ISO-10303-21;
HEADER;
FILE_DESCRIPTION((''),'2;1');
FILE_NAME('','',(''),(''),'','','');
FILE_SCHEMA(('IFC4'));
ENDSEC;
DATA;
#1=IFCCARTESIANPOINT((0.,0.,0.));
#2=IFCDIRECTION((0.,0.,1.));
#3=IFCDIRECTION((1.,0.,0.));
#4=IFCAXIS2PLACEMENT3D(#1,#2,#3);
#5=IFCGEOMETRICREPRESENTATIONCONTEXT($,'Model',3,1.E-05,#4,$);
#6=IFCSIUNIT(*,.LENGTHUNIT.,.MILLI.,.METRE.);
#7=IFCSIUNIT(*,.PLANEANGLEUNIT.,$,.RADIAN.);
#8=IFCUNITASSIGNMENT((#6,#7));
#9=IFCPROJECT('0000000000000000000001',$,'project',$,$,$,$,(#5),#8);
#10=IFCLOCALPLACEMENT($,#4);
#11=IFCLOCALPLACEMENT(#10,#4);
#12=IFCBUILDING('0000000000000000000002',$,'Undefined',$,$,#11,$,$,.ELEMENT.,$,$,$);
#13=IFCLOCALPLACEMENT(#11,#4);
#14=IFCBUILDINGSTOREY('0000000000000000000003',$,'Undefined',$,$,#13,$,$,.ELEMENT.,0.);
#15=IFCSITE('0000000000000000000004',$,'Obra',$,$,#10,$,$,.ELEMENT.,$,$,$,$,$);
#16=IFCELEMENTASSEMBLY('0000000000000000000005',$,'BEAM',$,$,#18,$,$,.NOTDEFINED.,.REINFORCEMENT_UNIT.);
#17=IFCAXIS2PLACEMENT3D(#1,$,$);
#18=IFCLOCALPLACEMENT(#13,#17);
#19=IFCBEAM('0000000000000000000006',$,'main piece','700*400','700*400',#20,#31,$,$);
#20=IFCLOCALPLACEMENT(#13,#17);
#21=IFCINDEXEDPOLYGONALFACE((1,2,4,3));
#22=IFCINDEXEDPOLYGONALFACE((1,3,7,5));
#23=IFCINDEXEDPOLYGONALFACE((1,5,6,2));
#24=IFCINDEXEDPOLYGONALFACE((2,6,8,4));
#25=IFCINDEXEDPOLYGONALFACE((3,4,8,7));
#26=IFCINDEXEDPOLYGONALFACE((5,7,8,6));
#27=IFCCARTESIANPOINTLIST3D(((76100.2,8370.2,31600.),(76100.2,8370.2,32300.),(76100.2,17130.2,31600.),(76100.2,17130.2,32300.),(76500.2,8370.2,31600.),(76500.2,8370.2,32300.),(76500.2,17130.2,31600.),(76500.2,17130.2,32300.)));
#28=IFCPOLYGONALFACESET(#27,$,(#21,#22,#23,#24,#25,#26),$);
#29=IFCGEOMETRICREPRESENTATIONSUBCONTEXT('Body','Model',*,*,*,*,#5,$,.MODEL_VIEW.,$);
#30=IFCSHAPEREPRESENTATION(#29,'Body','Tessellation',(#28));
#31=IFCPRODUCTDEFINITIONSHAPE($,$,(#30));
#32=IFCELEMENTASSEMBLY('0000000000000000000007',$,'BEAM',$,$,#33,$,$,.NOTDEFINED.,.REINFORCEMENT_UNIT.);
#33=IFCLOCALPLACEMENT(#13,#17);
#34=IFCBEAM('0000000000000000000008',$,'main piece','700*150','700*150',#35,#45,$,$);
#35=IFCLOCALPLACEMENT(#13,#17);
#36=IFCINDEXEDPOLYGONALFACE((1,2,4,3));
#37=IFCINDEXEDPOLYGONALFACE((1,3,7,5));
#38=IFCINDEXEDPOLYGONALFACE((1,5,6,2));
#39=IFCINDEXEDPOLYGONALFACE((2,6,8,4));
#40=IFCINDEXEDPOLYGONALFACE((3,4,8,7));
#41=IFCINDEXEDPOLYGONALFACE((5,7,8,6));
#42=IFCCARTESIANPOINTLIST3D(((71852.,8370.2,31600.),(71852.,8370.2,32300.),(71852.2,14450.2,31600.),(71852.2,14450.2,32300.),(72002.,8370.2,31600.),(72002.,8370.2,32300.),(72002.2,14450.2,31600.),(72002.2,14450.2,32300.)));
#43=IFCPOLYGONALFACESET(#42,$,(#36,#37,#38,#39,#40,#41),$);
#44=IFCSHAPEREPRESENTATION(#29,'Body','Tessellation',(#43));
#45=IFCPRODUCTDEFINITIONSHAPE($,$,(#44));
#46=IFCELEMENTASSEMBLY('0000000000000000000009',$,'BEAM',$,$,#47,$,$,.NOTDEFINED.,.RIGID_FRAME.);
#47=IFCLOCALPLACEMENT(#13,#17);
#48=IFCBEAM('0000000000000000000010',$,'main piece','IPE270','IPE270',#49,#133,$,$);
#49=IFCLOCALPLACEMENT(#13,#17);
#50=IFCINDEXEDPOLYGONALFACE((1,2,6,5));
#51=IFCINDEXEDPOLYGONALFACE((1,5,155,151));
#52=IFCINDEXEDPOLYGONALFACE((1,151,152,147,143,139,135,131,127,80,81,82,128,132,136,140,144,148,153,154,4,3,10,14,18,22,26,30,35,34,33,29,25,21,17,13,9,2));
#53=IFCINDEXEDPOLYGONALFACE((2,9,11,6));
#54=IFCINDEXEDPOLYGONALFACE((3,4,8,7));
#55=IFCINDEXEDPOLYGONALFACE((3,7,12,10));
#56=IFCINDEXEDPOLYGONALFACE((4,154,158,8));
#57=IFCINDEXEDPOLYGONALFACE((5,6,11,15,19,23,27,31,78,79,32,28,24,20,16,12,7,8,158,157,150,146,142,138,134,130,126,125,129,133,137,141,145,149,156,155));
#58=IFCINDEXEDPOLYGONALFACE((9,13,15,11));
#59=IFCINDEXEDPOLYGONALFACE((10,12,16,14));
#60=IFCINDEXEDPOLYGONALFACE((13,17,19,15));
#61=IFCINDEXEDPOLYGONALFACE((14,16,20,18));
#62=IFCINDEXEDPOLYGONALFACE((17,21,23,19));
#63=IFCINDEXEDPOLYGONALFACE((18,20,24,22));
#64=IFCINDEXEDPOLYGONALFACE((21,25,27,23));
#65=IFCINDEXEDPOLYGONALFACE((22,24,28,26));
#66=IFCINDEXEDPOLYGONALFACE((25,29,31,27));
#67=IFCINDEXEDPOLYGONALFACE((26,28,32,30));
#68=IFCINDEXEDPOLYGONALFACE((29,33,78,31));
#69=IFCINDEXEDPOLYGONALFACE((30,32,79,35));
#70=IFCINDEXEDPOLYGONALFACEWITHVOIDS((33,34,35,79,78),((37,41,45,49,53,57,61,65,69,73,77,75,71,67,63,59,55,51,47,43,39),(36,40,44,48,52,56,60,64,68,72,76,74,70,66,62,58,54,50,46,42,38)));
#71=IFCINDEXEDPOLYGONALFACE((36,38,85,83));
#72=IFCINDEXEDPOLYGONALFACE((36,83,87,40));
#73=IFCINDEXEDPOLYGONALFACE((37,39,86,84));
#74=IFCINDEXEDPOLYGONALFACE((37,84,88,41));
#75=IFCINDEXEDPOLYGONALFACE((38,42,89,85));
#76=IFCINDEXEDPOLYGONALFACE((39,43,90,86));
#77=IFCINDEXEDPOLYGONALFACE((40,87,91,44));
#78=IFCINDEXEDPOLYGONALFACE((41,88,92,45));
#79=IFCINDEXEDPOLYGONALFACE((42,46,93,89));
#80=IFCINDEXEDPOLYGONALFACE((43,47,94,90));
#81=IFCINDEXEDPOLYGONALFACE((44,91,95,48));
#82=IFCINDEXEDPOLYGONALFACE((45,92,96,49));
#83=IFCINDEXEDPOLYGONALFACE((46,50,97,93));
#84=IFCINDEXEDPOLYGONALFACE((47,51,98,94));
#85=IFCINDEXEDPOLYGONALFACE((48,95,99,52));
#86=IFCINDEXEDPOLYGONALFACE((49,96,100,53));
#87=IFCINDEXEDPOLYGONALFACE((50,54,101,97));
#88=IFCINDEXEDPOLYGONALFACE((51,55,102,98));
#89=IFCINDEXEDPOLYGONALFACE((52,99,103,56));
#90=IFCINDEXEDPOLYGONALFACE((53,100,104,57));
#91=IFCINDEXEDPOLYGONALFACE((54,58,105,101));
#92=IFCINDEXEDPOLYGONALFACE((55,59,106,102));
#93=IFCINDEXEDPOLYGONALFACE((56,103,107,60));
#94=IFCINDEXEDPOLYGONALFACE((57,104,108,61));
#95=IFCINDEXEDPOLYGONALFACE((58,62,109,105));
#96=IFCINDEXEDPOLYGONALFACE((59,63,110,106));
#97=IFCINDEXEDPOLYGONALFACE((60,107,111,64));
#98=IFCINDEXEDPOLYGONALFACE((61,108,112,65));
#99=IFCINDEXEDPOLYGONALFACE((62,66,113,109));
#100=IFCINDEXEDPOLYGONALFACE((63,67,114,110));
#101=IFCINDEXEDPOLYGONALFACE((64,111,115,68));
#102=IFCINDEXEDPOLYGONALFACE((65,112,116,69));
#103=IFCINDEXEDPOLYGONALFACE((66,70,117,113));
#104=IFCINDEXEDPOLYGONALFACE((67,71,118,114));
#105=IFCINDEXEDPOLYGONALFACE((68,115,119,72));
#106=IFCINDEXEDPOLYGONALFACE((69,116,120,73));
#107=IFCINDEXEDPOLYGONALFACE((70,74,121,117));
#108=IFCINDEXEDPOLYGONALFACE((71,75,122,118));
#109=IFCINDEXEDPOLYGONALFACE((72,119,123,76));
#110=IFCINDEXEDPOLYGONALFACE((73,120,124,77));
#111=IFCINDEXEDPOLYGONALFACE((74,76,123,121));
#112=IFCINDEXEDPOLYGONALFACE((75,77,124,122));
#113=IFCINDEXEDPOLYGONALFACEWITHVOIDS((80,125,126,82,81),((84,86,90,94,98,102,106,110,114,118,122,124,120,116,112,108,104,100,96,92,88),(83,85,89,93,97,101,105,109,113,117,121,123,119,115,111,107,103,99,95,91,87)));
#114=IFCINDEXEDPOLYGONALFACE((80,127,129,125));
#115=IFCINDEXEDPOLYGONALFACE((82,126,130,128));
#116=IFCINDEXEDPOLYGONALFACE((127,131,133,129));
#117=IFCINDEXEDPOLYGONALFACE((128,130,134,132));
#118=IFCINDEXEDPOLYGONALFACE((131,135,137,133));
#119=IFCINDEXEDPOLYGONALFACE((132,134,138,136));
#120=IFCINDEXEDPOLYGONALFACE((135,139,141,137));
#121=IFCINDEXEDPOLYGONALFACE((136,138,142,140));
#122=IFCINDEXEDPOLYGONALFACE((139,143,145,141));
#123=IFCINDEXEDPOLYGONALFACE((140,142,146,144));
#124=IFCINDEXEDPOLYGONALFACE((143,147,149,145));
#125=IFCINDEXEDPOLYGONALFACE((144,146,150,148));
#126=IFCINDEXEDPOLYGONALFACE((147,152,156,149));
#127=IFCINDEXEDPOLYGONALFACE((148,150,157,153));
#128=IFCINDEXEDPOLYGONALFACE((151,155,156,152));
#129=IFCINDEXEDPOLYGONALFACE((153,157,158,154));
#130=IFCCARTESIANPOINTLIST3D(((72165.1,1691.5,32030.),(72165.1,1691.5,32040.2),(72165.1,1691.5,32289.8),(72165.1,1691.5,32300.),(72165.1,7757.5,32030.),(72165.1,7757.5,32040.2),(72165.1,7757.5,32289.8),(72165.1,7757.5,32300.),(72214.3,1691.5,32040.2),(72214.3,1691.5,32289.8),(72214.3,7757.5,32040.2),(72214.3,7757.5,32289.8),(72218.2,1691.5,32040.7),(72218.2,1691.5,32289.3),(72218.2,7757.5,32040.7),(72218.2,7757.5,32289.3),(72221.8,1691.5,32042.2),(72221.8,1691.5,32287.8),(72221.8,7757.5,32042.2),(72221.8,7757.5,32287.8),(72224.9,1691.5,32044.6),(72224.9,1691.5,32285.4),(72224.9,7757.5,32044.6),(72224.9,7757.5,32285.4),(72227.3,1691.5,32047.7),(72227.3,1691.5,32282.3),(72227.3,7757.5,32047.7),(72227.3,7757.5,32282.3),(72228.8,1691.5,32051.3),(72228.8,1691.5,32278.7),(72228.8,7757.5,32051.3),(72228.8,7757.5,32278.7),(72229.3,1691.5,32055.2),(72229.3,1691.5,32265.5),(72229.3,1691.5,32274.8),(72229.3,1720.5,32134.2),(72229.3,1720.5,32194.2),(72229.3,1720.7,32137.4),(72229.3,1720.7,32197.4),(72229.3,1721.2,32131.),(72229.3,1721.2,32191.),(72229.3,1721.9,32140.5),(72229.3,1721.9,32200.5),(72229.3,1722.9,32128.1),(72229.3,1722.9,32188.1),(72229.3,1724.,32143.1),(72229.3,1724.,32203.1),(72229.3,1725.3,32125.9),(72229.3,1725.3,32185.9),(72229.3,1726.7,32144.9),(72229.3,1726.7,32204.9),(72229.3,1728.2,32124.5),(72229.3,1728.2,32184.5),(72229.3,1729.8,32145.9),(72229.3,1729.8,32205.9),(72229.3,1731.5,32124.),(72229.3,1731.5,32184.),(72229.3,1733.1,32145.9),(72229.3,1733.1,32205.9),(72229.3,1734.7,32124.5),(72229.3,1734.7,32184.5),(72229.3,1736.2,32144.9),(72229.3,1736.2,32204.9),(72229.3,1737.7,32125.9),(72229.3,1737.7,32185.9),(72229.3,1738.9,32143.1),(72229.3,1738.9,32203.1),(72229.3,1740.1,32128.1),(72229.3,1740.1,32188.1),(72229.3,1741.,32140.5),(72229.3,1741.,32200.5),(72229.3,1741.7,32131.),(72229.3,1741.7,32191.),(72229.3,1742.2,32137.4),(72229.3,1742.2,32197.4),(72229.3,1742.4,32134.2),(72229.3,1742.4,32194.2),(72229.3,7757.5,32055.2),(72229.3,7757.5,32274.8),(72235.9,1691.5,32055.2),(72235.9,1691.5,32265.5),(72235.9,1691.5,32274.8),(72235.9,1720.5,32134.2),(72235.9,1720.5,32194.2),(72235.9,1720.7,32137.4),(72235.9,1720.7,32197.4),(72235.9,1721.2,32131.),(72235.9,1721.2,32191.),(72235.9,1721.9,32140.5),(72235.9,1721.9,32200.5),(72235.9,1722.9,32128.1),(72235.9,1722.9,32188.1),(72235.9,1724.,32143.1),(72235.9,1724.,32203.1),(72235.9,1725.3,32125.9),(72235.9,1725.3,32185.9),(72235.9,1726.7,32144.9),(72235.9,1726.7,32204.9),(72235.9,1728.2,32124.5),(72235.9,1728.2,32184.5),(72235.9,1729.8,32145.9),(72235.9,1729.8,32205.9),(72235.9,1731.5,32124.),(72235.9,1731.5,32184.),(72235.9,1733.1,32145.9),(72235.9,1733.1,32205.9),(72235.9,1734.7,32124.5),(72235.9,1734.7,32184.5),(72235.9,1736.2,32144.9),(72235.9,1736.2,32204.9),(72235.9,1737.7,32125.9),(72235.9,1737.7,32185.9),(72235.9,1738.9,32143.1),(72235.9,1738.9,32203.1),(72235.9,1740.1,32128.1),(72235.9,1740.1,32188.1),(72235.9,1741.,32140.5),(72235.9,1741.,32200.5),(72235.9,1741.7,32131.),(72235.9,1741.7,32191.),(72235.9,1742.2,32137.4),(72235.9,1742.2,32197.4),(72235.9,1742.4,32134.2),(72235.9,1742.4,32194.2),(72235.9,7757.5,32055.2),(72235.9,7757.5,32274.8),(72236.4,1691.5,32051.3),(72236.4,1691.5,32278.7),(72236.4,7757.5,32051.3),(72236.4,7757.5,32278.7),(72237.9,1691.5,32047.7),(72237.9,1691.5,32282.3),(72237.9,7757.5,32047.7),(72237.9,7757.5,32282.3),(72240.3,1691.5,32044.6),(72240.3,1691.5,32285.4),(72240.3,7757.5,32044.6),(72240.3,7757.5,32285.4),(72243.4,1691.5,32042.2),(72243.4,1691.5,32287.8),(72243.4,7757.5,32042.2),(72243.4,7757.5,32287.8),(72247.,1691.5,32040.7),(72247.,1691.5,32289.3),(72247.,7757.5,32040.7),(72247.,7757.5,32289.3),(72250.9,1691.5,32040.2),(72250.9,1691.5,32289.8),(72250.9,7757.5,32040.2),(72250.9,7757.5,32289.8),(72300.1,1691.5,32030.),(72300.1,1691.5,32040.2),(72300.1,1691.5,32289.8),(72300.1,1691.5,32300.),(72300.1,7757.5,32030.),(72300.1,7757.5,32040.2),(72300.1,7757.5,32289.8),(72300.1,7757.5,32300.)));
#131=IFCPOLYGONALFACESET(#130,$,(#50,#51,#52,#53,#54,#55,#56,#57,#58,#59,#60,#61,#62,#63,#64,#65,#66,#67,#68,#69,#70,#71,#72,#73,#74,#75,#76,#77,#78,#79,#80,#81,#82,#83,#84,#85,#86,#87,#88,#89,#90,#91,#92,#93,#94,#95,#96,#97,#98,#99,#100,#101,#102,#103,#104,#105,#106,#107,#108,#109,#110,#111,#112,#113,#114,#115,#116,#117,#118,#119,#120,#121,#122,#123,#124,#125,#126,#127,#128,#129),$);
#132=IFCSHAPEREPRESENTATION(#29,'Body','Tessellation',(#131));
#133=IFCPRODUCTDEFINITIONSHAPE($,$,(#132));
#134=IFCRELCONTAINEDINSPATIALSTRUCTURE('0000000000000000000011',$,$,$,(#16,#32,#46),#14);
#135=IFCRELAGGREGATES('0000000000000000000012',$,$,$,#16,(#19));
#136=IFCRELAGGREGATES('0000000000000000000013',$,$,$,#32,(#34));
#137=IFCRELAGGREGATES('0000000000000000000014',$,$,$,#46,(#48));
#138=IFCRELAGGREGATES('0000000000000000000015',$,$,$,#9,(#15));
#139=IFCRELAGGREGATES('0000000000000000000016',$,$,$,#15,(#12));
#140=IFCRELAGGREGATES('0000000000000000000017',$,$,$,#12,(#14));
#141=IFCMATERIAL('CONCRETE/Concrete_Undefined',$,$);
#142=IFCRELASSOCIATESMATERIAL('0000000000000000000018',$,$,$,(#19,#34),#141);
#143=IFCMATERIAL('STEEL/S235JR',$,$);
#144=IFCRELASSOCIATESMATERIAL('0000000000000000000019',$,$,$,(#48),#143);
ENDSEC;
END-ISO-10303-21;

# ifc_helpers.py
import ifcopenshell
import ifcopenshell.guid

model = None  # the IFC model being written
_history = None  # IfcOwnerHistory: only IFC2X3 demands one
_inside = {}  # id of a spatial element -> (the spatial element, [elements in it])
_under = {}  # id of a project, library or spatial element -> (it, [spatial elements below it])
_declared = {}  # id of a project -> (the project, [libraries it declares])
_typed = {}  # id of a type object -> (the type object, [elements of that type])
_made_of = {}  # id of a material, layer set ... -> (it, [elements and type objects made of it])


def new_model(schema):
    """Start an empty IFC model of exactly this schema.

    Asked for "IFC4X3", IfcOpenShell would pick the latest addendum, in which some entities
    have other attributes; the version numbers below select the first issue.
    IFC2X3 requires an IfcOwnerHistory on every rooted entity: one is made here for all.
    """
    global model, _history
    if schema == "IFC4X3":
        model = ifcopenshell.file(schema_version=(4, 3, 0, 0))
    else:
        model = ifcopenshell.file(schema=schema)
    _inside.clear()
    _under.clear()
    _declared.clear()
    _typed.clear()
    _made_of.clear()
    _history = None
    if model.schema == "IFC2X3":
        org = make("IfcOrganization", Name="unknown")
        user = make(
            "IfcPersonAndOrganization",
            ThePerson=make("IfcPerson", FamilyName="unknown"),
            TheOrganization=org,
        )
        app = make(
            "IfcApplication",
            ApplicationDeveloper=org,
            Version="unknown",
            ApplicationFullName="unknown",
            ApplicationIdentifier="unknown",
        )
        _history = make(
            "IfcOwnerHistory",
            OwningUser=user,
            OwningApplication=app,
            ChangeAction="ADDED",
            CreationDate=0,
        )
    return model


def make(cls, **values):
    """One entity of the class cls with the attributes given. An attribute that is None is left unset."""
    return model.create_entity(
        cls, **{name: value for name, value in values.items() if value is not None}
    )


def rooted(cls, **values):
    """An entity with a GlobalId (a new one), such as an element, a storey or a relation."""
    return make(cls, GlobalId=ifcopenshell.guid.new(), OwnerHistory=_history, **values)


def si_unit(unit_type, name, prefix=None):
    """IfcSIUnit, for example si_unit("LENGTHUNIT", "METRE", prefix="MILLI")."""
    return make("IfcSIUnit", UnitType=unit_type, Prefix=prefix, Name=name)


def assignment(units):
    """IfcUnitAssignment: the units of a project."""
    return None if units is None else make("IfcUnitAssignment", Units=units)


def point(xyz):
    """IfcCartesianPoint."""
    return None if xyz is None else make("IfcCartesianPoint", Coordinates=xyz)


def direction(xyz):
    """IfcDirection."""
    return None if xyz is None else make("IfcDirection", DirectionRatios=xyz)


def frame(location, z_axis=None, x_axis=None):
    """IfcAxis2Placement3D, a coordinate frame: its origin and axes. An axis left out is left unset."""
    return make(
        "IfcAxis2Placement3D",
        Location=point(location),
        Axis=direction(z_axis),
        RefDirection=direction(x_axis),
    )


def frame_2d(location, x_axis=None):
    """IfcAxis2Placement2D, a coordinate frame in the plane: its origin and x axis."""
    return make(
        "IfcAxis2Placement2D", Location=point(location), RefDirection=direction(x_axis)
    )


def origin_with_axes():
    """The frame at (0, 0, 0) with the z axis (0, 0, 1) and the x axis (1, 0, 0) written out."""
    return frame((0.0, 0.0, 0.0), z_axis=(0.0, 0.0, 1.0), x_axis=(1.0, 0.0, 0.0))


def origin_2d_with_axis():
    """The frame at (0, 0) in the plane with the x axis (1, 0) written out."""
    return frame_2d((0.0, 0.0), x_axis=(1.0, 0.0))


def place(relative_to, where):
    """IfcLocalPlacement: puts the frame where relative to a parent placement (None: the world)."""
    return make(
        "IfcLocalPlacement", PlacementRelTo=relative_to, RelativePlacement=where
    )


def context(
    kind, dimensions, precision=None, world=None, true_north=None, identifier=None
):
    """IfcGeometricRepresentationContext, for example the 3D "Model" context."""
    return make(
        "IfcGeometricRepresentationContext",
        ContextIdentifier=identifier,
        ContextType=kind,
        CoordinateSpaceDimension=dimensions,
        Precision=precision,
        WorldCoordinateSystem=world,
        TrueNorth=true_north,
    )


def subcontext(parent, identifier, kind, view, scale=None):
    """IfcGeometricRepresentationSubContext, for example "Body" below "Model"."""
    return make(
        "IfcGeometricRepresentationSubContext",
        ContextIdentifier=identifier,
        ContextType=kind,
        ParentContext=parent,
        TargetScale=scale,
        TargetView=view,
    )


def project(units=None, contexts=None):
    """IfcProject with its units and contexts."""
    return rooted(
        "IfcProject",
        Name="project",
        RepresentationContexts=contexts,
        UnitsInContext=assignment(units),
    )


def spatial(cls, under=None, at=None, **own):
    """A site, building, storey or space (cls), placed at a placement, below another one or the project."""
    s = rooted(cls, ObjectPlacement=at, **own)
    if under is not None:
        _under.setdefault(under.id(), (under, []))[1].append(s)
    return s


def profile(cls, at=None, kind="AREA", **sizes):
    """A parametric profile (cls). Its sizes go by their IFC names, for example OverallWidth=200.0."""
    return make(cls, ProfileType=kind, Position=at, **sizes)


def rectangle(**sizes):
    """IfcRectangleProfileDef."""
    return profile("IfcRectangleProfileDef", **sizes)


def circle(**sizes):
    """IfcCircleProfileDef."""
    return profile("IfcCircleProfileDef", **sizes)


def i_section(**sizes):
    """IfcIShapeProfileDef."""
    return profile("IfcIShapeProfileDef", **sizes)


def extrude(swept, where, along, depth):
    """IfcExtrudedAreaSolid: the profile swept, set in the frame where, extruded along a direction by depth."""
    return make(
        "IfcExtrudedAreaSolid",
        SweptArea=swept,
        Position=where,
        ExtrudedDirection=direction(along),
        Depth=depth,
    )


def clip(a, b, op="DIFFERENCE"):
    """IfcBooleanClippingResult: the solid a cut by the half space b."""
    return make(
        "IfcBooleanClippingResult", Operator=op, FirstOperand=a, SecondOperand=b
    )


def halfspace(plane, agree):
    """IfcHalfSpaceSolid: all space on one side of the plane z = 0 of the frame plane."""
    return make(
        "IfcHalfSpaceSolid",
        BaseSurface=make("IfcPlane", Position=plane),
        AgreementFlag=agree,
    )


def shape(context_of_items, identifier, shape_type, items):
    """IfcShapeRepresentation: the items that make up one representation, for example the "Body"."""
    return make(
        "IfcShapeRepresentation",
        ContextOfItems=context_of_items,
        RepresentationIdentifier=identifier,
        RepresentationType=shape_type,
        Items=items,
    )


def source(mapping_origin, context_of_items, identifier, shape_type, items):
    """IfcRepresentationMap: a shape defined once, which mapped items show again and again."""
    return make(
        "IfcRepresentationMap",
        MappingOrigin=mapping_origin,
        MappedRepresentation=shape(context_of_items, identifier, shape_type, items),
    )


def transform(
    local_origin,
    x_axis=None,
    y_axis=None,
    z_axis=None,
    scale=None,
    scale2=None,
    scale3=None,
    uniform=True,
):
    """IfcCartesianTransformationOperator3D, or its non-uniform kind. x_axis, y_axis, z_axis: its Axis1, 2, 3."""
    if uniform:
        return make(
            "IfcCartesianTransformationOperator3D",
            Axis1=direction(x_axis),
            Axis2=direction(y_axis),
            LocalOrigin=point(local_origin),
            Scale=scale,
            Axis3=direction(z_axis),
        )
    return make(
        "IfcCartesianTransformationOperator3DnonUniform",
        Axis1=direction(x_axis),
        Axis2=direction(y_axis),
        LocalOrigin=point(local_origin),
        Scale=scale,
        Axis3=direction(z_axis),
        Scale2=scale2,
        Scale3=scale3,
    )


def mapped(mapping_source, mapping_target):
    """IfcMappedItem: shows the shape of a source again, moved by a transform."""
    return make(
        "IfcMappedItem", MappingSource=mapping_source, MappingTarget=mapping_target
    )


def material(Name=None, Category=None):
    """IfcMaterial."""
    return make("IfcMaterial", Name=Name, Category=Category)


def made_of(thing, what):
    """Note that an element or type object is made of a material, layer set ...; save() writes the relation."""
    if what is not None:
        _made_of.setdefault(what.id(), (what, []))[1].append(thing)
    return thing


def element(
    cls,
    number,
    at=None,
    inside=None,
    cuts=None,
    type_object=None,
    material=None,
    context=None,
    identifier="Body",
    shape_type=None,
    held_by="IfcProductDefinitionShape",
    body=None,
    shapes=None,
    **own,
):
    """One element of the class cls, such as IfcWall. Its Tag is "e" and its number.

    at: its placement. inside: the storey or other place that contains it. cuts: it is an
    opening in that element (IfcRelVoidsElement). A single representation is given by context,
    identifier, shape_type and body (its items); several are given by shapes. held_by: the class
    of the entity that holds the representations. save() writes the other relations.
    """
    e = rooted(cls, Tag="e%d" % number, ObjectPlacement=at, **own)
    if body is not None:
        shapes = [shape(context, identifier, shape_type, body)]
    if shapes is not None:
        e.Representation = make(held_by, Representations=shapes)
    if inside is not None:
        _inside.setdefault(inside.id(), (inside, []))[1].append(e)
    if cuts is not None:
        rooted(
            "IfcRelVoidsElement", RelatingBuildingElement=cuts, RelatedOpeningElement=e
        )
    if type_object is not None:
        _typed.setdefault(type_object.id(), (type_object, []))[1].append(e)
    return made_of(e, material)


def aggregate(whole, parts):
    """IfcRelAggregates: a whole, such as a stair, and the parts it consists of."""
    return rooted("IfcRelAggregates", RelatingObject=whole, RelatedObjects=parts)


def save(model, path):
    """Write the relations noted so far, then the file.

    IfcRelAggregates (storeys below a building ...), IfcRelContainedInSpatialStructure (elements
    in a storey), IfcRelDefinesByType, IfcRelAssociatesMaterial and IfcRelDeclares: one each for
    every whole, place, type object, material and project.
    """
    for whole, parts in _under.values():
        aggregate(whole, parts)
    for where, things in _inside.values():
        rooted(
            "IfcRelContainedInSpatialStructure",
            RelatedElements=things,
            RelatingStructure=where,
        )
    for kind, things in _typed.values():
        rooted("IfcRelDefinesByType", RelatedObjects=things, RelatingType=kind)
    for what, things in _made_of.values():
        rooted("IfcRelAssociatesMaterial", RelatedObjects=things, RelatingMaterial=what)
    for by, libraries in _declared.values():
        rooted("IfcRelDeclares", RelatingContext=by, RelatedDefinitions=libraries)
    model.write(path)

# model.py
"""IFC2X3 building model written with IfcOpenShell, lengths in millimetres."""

from ifc_helpers import new_model, si_unit, frame, origin_with_axes, origin_2d_with_axis, place, context, subcontext, project, spatial, rectangle, circle, i_section, extrude, clip, halfspace, source, transform, mapped, material, element, aggregate, save


model = new_model("IFC2X3")

# Units and contexts
model_context = context("Model", 3, precision=1e-05, world=origin_with_axes())
body_context = subcontext(model_context, "Body", "Model", "MODEL_VIEW")
ifc_project = project(units=[si_unit("LENGTHUNIT", "METRE", prefix="MILLI"), si_unit("PLANEANGLEUNIT", "RADIAN")], contexts=[model_context])

# Site, building, storey
site_placement = place(None, origin_with_axes())
site = spatial("IfcSite", under=ifc_project, at=site_placement, Name="Obra", CompositionType="ELEMENT")
building_placement = place(site_placement, origin_with_axes())
building = spatial("IfcBuilding", under=site, at=building_placement, Name="Undefined", CompositionType="ELEMENT")
storey_placement = place(building_placement, origin_with_axes())
storey = spatial("IfcBuildingStorey", under=building, at=storey_placement, Name="Undefined", CompositionType="ELEMENT", Elevation=0.0)

# Shared definitions
ifc_material_1 = material(Name="STEEL/S235JR")

# Element assemblies, beams
assembly_1_placement = place(storey_placement, origin_with_axes())
assembly_1 = element("IfcElementAssembly", 1, at=assembly_1_placement, inside=storey, Name="BEAM", AssemblyPlace="NOTDEFINED", PredefinedType="REINFORCEMENT_UNIT")
ifc_material_2 = material(Name="CONCRETE/Concrete_Undefined")
beam_1_placement = place(assembly_1_placement, frame((76300.2, 8370.2, 31950.0), z_axis=(0.0, 0.0, 1.0), x_axis=(0.0, 1.0, 0.0)))
beam_1 = element("IfcBeam", 2, at=beam_1_placement, material=ifc_material_2, Name="main piece", Description="700*400", ObjectType="700*400", context=body_context, shape_type="SweptSolid", body=[
    extrude(rectangle(XDim=400.0, YDim=700.0, at=origin_2d_with_axis()), frame((8760.0, 0.0, 0.0), z_axis=(-1.0, 0.0, 0.0), x_axis=(0.0, -1.0, 0.0)), (0.0, 0.0, 1.0), 8760.0),
])
aggregate(assembly_1, [beam_1])
assembly_2_placement = place(storey_placement, origin_with_axes())
assembly_2 = element("IfcElementAssembly", 3, at=assembly_2_placement, inside=storey, Name="BEAM", AssemblyPlace="NOTDEFINED", PredefinedType="REINFORCEMENT_UNIT")
beam_2_placement = place(assembly_2_placement, frame((71927.0, 8370.2, 31950.0), z_axis=(0.0, 0.0, 1.0), x_axis=(0.000033, 1.0, 0.0)))
beam_2 = element("IfcBeam", 4, at=beam_2_placement, material=ifc_material_2, Name="main piece", Description="700*150", ObjectType="700*150", context=body_context, shape_type="SweptSolid", body=[
    extrude(rectangle(XDim=150.0, YDim=700.0, at=origin_2d_with_axis()), frame((6080.0, 0.0, 0.0), z_axis=(-1.0, 0.0, 0.0), x_axis=(0.0, -1.0, 0.0)), (0.0, 0.0, 1.0), 6080.0),
])
aggregate(assembly_2, [beam_2])

# Element assembly, beam, openings
assembly_3_placement = place(storey_placement, origin_with_axes())
assembly_3 = element("IfcElementAssembly", 5, at=assembly_3_placement, inside=storey, Name="BEAM", AssemblyPlace="NOTDEFINED", PredefinedType="RIGID_FRAME")
beam_3_placement = place(assembly_3_placement, frame((72232.6, 7757.5, 32165.0), z_axis=(0.0, 0.0, 1.0), x_axis=(0.0, -1.0, 0.0)))
beam_3 = element("IfcBeam", 6, at=beam_3_placement, material=ifc_material_1, Name="main piece", Description="IPE270", ObjectType="IPE270", context=body_context, shape_type="Clipping", body=[
    clip(extrude(i_section(OverallWidth=135.0, OverallDepth=270.0, WebThickness=6.6, FlangeThickness=10.2, FilletRadius=15.0, at=origin_2d_with_axis()), frame((6066.0, 0.0, 0.0), z_axis=(-1.0, 0.0, 0.0), x_axis=(0.0, -1.0, 0.0)), (0.0, 0.0, 1.0), 6066.0), halfspace(frame((6066.0, 0.0, -235.0), z_axis=(-1.0, -0.000013, 0.0), x_axis=(-0.000014, 1.0, 0.0)), True)),
])
opening_1_placement = place(assembly_3_placement, frame((72232.6, 7757.5, 32165.0), z_axis=(0.0, 0.0, 1.0), x_axis=(0.0, -1.0, 0.0)))
element("IfcOpeningElement", 7, at=opening_1_placement, cuts=beam_3, ObjectType="Recess", context=body_context, shape_type="SweptSolid", body=[
    extrude(rectangle(XDim=35.5, YDim=97.7, at=origin_2d_with_axis()), frame((6114.9, 68.6, 118.2), z_axis=(0.000013, -1.0, 0.0), x_axis=(0.0, 0.0, -1.0)), (0.0, 0.0, 1.0), 137.1),
])
shared_shape_1 = source(origin_with_axes(), body_context, "Body", "SweptSolid", [
    extrude(circle(Radius=11.0, at=origin_2d_with_axis()), frame((0.0, -3.4, 0.0), z_axis=(0.0, 1.0, 0.0), x_axis=(1.0, 0.0, 0.0)), (0.0, 0.0, 1.0), 6.8),
])
opening_2_placement = place(assembly_3_placement, frame((72232.6, 1691.5, 32235.0), z_axis=(-0.000014, 1.0, 0.0), x_axis=(0.0, 0.0, -1.0)))
element("IfcOpeningElement", 8, at=opening_2_placement, cuts=beam_3, ObjectType="Opening", context=body_context, shape_type="MappedRepresentation", body=[
    mapped(shared_shape_1, transform((40.0, 0.0, 40.0))),
    mapped(shared_shape_1, transform((100.0, 0.0, 40.0))),
])
aggregate(assembly_3, [beam_3])

save(model, "model.ifc")
